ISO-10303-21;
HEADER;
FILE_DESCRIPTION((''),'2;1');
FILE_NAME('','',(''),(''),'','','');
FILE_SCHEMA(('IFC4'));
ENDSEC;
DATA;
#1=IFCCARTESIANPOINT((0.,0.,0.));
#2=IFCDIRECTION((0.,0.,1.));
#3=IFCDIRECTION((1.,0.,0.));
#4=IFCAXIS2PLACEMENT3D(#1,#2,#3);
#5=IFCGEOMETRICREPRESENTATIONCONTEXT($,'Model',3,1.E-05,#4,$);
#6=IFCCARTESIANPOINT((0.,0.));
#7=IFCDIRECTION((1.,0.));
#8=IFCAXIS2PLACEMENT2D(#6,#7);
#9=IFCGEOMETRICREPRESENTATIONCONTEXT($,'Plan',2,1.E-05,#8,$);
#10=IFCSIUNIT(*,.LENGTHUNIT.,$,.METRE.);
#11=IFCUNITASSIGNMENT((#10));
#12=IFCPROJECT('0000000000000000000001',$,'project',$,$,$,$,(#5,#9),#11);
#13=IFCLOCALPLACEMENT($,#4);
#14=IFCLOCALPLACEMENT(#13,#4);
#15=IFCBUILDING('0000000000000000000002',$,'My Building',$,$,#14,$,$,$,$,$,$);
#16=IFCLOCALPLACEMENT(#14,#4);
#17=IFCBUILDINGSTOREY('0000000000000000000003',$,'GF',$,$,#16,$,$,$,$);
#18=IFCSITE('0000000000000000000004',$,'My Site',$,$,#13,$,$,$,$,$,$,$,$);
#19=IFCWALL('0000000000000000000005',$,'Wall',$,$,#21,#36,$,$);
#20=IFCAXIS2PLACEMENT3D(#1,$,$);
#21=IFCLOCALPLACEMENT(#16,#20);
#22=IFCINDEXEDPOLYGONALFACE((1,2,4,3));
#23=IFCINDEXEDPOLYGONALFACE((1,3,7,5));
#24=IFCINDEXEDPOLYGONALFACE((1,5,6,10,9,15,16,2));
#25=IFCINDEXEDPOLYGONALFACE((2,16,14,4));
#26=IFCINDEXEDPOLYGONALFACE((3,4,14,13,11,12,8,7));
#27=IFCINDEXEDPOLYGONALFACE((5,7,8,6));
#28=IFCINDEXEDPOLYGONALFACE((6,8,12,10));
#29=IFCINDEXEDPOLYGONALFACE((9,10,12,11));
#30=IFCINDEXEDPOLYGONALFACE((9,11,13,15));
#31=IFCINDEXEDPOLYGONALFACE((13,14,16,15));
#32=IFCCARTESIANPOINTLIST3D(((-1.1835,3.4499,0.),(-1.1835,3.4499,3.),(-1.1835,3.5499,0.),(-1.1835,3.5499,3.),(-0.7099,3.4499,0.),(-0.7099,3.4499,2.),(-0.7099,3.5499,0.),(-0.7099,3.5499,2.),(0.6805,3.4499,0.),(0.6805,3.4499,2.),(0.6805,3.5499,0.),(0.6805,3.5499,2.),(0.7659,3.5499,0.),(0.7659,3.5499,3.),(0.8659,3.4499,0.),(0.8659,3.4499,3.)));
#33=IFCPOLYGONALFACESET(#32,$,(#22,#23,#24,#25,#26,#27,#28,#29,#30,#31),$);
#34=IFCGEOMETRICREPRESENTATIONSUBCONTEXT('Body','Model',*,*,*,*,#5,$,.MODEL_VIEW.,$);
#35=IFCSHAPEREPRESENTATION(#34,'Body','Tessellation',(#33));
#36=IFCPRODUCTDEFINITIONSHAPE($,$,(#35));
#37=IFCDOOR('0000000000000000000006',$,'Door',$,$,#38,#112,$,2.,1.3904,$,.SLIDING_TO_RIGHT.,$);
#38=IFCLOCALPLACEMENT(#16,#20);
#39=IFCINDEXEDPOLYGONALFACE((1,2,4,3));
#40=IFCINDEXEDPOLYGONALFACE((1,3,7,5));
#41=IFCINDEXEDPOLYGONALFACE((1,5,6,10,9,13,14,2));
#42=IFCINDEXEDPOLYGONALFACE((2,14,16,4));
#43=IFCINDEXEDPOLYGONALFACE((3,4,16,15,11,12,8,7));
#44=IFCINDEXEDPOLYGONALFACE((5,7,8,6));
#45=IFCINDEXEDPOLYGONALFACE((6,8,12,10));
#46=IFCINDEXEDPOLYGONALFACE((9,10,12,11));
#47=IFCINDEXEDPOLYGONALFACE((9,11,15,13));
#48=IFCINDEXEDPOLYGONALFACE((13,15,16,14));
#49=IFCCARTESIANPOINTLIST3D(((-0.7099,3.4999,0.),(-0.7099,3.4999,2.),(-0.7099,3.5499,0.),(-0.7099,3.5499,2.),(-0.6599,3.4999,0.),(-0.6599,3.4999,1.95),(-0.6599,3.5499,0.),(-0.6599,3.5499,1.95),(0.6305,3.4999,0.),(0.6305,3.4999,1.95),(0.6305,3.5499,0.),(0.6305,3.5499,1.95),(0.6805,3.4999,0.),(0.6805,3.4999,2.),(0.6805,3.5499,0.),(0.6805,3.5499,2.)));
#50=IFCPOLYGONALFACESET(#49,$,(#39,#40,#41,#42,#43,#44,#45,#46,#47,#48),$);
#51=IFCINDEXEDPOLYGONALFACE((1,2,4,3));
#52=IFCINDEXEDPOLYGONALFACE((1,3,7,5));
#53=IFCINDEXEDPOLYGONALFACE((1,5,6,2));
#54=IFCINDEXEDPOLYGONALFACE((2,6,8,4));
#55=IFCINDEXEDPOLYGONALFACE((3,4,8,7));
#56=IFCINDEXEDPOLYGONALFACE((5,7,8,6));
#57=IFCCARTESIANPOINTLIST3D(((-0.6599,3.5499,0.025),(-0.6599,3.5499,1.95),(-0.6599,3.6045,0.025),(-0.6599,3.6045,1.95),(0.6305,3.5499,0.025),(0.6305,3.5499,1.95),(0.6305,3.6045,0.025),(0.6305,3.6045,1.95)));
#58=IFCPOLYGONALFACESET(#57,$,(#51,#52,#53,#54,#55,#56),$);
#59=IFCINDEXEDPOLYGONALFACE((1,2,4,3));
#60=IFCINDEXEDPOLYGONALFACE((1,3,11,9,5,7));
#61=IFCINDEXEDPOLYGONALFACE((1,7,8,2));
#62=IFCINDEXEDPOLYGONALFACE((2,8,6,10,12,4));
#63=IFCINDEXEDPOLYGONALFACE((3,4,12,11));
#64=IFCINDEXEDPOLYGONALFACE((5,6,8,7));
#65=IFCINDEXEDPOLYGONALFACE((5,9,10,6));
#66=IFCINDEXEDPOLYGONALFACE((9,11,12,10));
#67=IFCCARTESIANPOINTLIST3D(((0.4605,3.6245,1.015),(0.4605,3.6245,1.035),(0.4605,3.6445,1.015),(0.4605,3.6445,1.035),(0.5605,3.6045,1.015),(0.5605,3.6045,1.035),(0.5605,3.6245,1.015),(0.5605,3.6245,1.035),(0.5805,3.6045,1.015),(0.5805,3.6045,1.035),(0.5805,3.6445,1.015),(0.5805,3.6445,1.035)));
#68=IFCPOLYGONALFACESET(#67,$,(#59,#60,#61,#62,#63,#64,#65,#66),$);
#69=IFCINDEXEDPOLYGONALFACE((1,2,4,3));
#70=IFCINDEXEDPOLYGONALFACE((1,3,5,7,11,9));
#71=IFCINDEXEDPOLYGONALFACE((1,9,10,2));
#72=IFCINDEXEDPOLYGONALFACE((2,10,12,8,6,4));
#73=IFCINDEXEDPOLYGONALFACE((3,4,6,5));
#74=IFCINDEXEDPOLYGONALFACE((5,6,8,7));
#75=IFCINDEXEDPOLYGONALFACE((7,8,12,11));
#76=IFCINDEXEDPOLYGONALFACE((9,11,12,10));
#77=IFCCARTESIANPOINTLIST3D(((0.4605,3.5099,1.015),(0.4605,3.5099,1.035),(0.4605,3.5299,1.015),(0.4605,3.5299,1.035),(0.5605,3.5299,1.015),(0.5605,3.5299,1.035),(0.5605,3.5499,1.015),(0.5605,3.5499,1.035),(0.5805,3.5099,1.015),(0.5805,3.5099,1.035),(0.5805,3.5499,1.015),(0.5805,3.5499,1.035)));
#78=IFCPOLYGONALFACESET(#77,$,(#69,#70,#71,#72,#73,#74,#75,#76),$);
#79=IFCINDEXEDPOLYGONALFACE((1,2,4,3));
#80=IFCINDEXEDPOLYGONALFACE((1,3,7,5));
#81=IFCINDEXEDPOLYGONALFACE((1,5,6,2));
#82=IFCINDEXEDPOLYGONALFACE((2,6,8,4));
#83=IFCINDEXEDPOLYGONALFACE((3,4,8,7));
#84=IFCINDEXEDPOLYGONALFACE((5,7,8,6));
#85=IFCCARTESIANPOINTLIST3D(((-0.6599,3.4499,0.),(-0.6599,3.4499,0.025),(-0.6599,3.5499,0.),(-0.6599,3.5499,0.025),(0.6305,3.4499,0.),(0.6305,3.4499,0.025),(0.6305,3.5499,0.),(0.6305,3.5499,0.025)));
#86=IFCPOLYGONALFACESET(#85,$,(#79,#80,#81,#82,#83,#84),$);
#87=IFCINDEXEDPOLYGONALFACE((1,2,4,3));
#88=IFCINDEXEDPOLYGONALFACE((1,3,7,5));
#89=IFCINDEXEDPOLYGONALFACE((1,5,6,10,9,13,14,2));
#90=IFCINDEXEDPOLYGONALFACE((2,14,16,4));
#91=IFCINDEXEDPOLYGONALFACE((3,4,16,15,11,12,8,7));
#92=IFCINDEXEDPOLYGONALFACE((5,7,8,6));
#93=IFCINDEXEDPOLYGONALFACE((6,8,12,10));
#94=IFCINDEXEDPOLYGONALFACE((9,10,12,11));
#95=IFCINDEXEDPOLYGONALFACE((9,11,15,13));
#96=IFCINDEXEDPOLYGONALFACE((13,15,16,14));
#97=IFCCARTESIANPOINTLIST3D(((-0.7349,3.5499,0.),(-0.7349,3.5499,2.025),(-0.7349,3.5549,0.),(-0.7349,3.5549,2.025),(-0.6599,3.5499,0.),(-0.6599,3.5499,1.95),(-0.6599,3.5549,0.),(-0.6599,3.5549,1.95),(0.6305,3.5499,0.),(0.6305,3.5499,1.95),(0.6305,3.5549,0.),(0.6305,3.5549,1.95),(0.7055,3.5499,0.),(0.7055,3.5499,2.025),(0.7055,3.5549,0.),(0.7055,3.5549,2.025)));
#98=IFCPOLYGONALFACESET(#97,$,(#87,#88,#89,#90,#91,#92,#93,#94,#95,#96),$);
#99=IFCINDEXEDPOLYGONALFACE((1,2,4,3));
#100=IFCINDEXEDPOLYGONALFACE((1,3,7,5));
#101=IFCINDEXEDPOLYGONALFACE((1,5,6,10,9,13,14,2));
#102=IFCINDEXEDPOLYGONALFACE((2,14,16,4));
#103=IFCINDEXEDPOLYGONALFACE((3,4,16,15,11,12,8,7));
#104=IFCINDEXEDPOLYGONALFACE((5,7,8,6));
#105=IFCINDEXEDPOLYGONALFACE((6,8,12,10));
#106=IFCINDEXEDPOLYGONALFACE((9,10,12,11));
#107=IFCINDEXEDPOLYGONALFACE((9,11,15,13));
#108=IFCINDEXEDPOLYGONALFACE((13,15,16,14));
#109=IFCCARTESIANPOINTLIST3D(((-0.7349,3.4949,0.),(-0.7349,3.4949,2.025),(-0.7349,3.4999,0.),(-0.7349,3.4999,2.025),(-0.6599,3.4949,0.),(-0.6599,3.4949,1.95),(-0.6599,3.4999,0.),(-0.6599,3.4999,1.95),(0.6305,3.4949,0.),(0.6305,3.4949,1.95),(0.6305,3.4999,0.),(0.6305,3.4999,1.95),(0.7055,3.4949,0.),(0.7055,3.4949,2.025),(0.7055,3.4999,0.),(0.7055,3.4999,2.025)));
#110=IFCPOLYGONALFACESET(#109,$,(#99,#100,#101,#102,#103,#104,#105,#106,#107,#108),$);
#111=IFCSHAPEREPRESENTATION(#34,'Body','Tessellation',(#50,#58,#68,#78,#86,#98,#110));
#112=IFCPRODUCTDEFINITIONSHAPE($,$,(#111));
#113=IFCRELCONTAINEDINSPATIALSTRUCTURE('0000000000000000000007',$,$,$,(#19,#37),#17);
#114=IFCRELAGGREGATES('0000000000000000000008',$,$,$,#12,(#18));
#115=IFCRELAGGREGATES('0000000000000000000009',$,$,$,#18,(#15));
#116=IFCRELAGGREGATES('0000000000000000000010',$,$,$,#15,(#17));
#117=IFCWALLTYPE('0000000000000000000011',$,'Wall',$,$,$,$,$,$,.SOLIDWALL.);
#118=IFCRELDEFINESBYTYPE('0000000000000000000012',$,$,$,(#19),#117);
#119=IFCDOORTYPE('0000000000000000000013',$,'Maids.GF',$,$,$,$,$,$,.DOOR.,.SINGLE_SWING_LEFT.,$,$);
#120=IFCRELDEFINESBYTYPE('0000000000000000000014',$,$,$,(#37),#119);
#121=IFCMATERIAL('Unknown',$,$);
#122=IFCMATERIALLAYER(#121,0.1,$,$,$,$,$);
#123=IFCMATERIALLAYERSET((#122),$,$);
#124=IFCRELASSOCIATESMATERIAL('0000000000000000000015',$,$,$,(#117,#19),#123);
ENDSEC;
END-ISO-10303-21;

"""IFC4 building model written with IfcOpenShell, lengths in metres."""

from ifc_helpers import new_model, entity, si_unit, frame, origin_with_axes, origin_2d_with_axis, place, context, subcontext, project, spatial, line, indexed_curve, outline, extrude, shape, source, transform, mapped, material, layer, layer_set, layer_usage, type_object, type_shapes, element, fill, save


model = new_model("IFC4")

# Units and contexts
model_context = context("Model", 3, precision=1e-05, world=origin_with_axes())
plan_context = context("Plan", 2, precision=1e-05, world=origin_2d_with_axis())
body_context_1 = subcontext(model_context, "Body", "Model", "MODEL_VIEW")
body_context_2 = subcontext(plan_context, "Body", "Plan", "PLAN_VIEW")
ifc_project = project(units=[si_unit("LENGTHUNIT", "METRE")], contexts=[model_context, plan_context])

# Site, building, storey
site_placement = place(None, origin_with_axes())
site = spatial("IfcSite", under=ifc_project, at=site_placement, Name="My Site")
building_placement = place(site_placement, origin_with_axes())
building = spatial("IfcBuilding", under=site, at=building_placement, Name="My Building")
storey_placement = place(building_placement, origin_with_axes())
storey = spatial("IfcBuildingStorey", under=building, at=storey_placement, Name="GF")

# Shared definitions
ifc_material = material(Name="Unknown")

# Shared definitions
ifc_layer_1 = layer(ifc_material, 0.1)
ifc_layer_set_1 = layer_set([ifc_layer_1])
wall_type = type_object("IfcWallType", Name="Wall", PredefinedType="SOLIDWALL", material=ifc_layer_set_1)

# Wall, opening, door
ifc_layer_usage_1 = layer_usage(ifc_layer_set_1, "AXIS2", "POSITIVE", 0.0)
wall_1_placement = place(storey_placement, frame((0.7659, 3.5499, 0.0), z_axis=(0.0, 0.0, 1.0), x_axis=(-1.0, 0.0, 0.0)))
wall_1 = element("IfcWall", 1, at=wall_1_placement, inside=storey, type_object=wall_type, material=ifc_layer_usage_1, Name="Wall", context=body_context_1, shape_type="SweptSolid", body=[
    extrude(outline(indexed_curve([(0.0, 0.0), (-0.1, 0.1), (1.9494, 0.1), (1.9494, 0.0)], segments=[line(1, 2, 3, 4, 1)])), origin_with_axes(), (0.0, 0.0, 1.0), 3.0),
])
shared_shape_1 = source(origin_with_axes(), body_context_1, "Body", "SweptSolid", [
    extrude(outline(indexed_curve([(0.0, 0.0), (1.3904, 0.0), (1.3904, 2.0), (0.0, 2.0)], segments=[line(1, 2, 3, 4, 1)])), frame((0.0, -0.6, 0.0), z_axis=(0.0, -1.0, 0.0), x_axis=(1.0, 0.0, 0.0)), (0.0, 0.0, -1.0), 1.2),
])
opening_1_placement = place(wall_1_placement, frame((0.0853, 0.0, 0.0), z_axis=(0.0, 0.0, 1.0), x_axis=(1.0, 0.0, 0.0)))
opening_1 = element("IfcOpeningElement", 2, at=opening_1_placement, cuts=wall_1, PredefinedType="OPENING", context=body_context_1, shape_type="MappedRepresentation", body=[
    mapped(shared_shape_1, transform((0.0, 0.0, 0.0), x_axis=(1.0, 0.0, 0.0), y_axis=(0.0, 1.0, 0.0), z_axis=(0.0, 0.0, 1.0), scale=1.0)),
])
door_type_1 = type_object("IfcDoorType", Name="Maids.GF", OperationType="SINGLE_SWING_LEFT", PredefinedType="DOOR")
shared_shape_2 = source(origin_with_axes(), body_context_1, "Body", "SweptSolid", [
    extrude(outline(indexed_curve([(0.0, 0.0), (0.0, 2.0), (1.3904, 2.0), (1.3904, 0.0), (1.3404, 0.0), (1.3404, 1.95), (0.05, 1.95), (0.05, 0.0)], segments=[line(1, 2, 3, 4, 5, 6, 7, 8, 1)])), frame((0.0, 0.0, 0.0), z_axis=(0.0, -1.0, 0.0), x_axis=(1.0, 0.0, 0.0)), (0.0, 0.0, -1.0), 0.05),
    extrude(outline(indexed_curve([(0.0, 0.0), (1.2904, 0.0), (1.2904, 0.0547), (0.0, 0.0547)], segments=[line(1, 2, 3, 4, 1)])), frame((0.05, -0.0547, 0.025), z_axis=(0.0, 0.0, 1.0), x_axis=(1.0, 0.0, 0.0)), (0.0, 0.0, 1.0), 1.925),
    extrude(outline(indexed_curve([(0.0, 0.0), (0.0, -0.04), (0.12, -0.04), (0.12, -0.02), (0.02, -0.02), (0.02, 0.0)], segments=[line(1, 2, 3, 4, 5, 6, 1)])), frame((0.1, -0.0547, 1.015), z_axis=(0.0, 0.0, 1.0), x_axis=(1.0, 0.0, 0.0)), (0.0, 0.0, 1.0), 0.02),
    extrude(outline(indexed_curve([(0.0, 0.0), (0.0, 0.04), (0.12, 0.04), (0.12, 0.02), (0.02, 0.02), (0.02, 0.0)], segments=[line(1, 2, 3, 4, 5, 6, 1)])), frame((0.1, 0.0, 1.015), z_axis=(0.0, 0.0, 1.0), x_axis=(1.0, 0.0, 0.0)), (0.0, 0.0, 1.0), 0.02),
    extrude(outline(indexed_curve([(0.0, 0.0), (1.2904, 0.0), (1.2904, 0.1), (0.0, 0.1)], segments=[line(1, 2, 3, 4, 1)])), frame((0.05, 0.0, 0.0), z_axis=(0.0, 0.0, 1.0), x_axis=(1.0, 0.0, 0.0)), (0.0, 0.0, 1.0), 0.025),
    extrude(outline(indexed_curve([(0.0, 0.0), (0.0, 2.025), (1.4404, 2.025), (1.4404, 0.0), (1.3654, 0.0), (1.3654, 1.95), (0.075, 1.95), (0.075, 0.0)], segments=[line(1, 2, 3, 4, 5, 6, 7, 8, 1)])), frame((-0.025, -0.005, 0.0), z_axis=(0.0, -1.0, 0.0), x_axis=(1.0, 0.0, 0.0)), (0.0, 0.0, -1.0), 0.005),
    extrude(outline(indexed_curve([(0.0, 0.0), (0.0, 2.025), (1.4404, 2.025), (1.4404, 0.0), (1.3654, 0.0), (1.3654, 1.95), (0.075, 1.95), (0.075, 0.0)], segments=[line(1, 2, 3, 4, 5, 6, 7, 8, 1)])), frame((-0.025, 0.05, 0.0), z_axis=(0.0, -1.0, 0.0), x_axis=(1.0, 0.0, 0.0)), (0.0, 0.0, -1.0), 0.005),
])
shared_shape_3 = source(origin_with_axes(), body_context_2, "Body", "Curve2D", [
    entity("IfcIndexedPolyCurve", entity("IfcCartesianPointList2D", [[0.0, 0.0], [0.05, 0.0], [0.05, 0.05], [0.0, 0.05]]), [entity("IfcLineIndex", [1, 2, 3, 4, 1])]),
    entity("IfcIndexedPolyCurve", entity("IfcCartesianPointList2D", [[1.3904, 0.0], [1.3404, 0.0], [1.3404, 0.05], [1.3904, 0.05]]), [entity("IfcLineIndex", [1, 2, 3, 4, 1])]),
    entity("IfcIndexedPolyCurve", entity("IfcCartesianPointList2D", [[1.9856, -0.0547], [0.6952, -0.0547], [0.6952, 0.0], [1.9856, 0.0]]), [entity("IfcLineIndex", [1, 2, 3, 4, 1])]),
])
type_shapes(door_type_1, [shared_shape_2, shared_shape_3])
door_1_placement = place(opening_1_placement, frame((0.0, 0.0, 0.0), z_axis=(0.0, 0.0, 1.0), x_axis=(1.0, 0.0, 0.0)))
door_1 = element("IfcDoor", 3, at=door_1_placement, inside=storey, type_object=door_type_1, Name="Door", OperationType="SLIDING_TO_RIGHT", OverallHeight=2.0, OverallWidth=1.3904, shapes=[
    shape(body_context_1, "Body", "MappedRepresentation", [mapped(shared_shape_2, transform((0.0, 0.0, 0.0), x_axis=(1.0, 0.0, 0.0), y_axis=(0.0, 1.0, 0.0), z_axis=(0.0, 0.0, 1.0), scale=1.0))]),
    shape(body_context_2, "Body", "MappedRepresentation", [mapped(shared_shape_3, transform((0.0, 0.0, 0.0), x_axis=(1.0, 0.0, 0.0), y_axis=(0.0, 1.0, 0.0), z_axis=(0.0, 0.0, 1.0), scale=1.0))]),
])
fill(opening_1, door_1)

save(model, "model.ifc")
